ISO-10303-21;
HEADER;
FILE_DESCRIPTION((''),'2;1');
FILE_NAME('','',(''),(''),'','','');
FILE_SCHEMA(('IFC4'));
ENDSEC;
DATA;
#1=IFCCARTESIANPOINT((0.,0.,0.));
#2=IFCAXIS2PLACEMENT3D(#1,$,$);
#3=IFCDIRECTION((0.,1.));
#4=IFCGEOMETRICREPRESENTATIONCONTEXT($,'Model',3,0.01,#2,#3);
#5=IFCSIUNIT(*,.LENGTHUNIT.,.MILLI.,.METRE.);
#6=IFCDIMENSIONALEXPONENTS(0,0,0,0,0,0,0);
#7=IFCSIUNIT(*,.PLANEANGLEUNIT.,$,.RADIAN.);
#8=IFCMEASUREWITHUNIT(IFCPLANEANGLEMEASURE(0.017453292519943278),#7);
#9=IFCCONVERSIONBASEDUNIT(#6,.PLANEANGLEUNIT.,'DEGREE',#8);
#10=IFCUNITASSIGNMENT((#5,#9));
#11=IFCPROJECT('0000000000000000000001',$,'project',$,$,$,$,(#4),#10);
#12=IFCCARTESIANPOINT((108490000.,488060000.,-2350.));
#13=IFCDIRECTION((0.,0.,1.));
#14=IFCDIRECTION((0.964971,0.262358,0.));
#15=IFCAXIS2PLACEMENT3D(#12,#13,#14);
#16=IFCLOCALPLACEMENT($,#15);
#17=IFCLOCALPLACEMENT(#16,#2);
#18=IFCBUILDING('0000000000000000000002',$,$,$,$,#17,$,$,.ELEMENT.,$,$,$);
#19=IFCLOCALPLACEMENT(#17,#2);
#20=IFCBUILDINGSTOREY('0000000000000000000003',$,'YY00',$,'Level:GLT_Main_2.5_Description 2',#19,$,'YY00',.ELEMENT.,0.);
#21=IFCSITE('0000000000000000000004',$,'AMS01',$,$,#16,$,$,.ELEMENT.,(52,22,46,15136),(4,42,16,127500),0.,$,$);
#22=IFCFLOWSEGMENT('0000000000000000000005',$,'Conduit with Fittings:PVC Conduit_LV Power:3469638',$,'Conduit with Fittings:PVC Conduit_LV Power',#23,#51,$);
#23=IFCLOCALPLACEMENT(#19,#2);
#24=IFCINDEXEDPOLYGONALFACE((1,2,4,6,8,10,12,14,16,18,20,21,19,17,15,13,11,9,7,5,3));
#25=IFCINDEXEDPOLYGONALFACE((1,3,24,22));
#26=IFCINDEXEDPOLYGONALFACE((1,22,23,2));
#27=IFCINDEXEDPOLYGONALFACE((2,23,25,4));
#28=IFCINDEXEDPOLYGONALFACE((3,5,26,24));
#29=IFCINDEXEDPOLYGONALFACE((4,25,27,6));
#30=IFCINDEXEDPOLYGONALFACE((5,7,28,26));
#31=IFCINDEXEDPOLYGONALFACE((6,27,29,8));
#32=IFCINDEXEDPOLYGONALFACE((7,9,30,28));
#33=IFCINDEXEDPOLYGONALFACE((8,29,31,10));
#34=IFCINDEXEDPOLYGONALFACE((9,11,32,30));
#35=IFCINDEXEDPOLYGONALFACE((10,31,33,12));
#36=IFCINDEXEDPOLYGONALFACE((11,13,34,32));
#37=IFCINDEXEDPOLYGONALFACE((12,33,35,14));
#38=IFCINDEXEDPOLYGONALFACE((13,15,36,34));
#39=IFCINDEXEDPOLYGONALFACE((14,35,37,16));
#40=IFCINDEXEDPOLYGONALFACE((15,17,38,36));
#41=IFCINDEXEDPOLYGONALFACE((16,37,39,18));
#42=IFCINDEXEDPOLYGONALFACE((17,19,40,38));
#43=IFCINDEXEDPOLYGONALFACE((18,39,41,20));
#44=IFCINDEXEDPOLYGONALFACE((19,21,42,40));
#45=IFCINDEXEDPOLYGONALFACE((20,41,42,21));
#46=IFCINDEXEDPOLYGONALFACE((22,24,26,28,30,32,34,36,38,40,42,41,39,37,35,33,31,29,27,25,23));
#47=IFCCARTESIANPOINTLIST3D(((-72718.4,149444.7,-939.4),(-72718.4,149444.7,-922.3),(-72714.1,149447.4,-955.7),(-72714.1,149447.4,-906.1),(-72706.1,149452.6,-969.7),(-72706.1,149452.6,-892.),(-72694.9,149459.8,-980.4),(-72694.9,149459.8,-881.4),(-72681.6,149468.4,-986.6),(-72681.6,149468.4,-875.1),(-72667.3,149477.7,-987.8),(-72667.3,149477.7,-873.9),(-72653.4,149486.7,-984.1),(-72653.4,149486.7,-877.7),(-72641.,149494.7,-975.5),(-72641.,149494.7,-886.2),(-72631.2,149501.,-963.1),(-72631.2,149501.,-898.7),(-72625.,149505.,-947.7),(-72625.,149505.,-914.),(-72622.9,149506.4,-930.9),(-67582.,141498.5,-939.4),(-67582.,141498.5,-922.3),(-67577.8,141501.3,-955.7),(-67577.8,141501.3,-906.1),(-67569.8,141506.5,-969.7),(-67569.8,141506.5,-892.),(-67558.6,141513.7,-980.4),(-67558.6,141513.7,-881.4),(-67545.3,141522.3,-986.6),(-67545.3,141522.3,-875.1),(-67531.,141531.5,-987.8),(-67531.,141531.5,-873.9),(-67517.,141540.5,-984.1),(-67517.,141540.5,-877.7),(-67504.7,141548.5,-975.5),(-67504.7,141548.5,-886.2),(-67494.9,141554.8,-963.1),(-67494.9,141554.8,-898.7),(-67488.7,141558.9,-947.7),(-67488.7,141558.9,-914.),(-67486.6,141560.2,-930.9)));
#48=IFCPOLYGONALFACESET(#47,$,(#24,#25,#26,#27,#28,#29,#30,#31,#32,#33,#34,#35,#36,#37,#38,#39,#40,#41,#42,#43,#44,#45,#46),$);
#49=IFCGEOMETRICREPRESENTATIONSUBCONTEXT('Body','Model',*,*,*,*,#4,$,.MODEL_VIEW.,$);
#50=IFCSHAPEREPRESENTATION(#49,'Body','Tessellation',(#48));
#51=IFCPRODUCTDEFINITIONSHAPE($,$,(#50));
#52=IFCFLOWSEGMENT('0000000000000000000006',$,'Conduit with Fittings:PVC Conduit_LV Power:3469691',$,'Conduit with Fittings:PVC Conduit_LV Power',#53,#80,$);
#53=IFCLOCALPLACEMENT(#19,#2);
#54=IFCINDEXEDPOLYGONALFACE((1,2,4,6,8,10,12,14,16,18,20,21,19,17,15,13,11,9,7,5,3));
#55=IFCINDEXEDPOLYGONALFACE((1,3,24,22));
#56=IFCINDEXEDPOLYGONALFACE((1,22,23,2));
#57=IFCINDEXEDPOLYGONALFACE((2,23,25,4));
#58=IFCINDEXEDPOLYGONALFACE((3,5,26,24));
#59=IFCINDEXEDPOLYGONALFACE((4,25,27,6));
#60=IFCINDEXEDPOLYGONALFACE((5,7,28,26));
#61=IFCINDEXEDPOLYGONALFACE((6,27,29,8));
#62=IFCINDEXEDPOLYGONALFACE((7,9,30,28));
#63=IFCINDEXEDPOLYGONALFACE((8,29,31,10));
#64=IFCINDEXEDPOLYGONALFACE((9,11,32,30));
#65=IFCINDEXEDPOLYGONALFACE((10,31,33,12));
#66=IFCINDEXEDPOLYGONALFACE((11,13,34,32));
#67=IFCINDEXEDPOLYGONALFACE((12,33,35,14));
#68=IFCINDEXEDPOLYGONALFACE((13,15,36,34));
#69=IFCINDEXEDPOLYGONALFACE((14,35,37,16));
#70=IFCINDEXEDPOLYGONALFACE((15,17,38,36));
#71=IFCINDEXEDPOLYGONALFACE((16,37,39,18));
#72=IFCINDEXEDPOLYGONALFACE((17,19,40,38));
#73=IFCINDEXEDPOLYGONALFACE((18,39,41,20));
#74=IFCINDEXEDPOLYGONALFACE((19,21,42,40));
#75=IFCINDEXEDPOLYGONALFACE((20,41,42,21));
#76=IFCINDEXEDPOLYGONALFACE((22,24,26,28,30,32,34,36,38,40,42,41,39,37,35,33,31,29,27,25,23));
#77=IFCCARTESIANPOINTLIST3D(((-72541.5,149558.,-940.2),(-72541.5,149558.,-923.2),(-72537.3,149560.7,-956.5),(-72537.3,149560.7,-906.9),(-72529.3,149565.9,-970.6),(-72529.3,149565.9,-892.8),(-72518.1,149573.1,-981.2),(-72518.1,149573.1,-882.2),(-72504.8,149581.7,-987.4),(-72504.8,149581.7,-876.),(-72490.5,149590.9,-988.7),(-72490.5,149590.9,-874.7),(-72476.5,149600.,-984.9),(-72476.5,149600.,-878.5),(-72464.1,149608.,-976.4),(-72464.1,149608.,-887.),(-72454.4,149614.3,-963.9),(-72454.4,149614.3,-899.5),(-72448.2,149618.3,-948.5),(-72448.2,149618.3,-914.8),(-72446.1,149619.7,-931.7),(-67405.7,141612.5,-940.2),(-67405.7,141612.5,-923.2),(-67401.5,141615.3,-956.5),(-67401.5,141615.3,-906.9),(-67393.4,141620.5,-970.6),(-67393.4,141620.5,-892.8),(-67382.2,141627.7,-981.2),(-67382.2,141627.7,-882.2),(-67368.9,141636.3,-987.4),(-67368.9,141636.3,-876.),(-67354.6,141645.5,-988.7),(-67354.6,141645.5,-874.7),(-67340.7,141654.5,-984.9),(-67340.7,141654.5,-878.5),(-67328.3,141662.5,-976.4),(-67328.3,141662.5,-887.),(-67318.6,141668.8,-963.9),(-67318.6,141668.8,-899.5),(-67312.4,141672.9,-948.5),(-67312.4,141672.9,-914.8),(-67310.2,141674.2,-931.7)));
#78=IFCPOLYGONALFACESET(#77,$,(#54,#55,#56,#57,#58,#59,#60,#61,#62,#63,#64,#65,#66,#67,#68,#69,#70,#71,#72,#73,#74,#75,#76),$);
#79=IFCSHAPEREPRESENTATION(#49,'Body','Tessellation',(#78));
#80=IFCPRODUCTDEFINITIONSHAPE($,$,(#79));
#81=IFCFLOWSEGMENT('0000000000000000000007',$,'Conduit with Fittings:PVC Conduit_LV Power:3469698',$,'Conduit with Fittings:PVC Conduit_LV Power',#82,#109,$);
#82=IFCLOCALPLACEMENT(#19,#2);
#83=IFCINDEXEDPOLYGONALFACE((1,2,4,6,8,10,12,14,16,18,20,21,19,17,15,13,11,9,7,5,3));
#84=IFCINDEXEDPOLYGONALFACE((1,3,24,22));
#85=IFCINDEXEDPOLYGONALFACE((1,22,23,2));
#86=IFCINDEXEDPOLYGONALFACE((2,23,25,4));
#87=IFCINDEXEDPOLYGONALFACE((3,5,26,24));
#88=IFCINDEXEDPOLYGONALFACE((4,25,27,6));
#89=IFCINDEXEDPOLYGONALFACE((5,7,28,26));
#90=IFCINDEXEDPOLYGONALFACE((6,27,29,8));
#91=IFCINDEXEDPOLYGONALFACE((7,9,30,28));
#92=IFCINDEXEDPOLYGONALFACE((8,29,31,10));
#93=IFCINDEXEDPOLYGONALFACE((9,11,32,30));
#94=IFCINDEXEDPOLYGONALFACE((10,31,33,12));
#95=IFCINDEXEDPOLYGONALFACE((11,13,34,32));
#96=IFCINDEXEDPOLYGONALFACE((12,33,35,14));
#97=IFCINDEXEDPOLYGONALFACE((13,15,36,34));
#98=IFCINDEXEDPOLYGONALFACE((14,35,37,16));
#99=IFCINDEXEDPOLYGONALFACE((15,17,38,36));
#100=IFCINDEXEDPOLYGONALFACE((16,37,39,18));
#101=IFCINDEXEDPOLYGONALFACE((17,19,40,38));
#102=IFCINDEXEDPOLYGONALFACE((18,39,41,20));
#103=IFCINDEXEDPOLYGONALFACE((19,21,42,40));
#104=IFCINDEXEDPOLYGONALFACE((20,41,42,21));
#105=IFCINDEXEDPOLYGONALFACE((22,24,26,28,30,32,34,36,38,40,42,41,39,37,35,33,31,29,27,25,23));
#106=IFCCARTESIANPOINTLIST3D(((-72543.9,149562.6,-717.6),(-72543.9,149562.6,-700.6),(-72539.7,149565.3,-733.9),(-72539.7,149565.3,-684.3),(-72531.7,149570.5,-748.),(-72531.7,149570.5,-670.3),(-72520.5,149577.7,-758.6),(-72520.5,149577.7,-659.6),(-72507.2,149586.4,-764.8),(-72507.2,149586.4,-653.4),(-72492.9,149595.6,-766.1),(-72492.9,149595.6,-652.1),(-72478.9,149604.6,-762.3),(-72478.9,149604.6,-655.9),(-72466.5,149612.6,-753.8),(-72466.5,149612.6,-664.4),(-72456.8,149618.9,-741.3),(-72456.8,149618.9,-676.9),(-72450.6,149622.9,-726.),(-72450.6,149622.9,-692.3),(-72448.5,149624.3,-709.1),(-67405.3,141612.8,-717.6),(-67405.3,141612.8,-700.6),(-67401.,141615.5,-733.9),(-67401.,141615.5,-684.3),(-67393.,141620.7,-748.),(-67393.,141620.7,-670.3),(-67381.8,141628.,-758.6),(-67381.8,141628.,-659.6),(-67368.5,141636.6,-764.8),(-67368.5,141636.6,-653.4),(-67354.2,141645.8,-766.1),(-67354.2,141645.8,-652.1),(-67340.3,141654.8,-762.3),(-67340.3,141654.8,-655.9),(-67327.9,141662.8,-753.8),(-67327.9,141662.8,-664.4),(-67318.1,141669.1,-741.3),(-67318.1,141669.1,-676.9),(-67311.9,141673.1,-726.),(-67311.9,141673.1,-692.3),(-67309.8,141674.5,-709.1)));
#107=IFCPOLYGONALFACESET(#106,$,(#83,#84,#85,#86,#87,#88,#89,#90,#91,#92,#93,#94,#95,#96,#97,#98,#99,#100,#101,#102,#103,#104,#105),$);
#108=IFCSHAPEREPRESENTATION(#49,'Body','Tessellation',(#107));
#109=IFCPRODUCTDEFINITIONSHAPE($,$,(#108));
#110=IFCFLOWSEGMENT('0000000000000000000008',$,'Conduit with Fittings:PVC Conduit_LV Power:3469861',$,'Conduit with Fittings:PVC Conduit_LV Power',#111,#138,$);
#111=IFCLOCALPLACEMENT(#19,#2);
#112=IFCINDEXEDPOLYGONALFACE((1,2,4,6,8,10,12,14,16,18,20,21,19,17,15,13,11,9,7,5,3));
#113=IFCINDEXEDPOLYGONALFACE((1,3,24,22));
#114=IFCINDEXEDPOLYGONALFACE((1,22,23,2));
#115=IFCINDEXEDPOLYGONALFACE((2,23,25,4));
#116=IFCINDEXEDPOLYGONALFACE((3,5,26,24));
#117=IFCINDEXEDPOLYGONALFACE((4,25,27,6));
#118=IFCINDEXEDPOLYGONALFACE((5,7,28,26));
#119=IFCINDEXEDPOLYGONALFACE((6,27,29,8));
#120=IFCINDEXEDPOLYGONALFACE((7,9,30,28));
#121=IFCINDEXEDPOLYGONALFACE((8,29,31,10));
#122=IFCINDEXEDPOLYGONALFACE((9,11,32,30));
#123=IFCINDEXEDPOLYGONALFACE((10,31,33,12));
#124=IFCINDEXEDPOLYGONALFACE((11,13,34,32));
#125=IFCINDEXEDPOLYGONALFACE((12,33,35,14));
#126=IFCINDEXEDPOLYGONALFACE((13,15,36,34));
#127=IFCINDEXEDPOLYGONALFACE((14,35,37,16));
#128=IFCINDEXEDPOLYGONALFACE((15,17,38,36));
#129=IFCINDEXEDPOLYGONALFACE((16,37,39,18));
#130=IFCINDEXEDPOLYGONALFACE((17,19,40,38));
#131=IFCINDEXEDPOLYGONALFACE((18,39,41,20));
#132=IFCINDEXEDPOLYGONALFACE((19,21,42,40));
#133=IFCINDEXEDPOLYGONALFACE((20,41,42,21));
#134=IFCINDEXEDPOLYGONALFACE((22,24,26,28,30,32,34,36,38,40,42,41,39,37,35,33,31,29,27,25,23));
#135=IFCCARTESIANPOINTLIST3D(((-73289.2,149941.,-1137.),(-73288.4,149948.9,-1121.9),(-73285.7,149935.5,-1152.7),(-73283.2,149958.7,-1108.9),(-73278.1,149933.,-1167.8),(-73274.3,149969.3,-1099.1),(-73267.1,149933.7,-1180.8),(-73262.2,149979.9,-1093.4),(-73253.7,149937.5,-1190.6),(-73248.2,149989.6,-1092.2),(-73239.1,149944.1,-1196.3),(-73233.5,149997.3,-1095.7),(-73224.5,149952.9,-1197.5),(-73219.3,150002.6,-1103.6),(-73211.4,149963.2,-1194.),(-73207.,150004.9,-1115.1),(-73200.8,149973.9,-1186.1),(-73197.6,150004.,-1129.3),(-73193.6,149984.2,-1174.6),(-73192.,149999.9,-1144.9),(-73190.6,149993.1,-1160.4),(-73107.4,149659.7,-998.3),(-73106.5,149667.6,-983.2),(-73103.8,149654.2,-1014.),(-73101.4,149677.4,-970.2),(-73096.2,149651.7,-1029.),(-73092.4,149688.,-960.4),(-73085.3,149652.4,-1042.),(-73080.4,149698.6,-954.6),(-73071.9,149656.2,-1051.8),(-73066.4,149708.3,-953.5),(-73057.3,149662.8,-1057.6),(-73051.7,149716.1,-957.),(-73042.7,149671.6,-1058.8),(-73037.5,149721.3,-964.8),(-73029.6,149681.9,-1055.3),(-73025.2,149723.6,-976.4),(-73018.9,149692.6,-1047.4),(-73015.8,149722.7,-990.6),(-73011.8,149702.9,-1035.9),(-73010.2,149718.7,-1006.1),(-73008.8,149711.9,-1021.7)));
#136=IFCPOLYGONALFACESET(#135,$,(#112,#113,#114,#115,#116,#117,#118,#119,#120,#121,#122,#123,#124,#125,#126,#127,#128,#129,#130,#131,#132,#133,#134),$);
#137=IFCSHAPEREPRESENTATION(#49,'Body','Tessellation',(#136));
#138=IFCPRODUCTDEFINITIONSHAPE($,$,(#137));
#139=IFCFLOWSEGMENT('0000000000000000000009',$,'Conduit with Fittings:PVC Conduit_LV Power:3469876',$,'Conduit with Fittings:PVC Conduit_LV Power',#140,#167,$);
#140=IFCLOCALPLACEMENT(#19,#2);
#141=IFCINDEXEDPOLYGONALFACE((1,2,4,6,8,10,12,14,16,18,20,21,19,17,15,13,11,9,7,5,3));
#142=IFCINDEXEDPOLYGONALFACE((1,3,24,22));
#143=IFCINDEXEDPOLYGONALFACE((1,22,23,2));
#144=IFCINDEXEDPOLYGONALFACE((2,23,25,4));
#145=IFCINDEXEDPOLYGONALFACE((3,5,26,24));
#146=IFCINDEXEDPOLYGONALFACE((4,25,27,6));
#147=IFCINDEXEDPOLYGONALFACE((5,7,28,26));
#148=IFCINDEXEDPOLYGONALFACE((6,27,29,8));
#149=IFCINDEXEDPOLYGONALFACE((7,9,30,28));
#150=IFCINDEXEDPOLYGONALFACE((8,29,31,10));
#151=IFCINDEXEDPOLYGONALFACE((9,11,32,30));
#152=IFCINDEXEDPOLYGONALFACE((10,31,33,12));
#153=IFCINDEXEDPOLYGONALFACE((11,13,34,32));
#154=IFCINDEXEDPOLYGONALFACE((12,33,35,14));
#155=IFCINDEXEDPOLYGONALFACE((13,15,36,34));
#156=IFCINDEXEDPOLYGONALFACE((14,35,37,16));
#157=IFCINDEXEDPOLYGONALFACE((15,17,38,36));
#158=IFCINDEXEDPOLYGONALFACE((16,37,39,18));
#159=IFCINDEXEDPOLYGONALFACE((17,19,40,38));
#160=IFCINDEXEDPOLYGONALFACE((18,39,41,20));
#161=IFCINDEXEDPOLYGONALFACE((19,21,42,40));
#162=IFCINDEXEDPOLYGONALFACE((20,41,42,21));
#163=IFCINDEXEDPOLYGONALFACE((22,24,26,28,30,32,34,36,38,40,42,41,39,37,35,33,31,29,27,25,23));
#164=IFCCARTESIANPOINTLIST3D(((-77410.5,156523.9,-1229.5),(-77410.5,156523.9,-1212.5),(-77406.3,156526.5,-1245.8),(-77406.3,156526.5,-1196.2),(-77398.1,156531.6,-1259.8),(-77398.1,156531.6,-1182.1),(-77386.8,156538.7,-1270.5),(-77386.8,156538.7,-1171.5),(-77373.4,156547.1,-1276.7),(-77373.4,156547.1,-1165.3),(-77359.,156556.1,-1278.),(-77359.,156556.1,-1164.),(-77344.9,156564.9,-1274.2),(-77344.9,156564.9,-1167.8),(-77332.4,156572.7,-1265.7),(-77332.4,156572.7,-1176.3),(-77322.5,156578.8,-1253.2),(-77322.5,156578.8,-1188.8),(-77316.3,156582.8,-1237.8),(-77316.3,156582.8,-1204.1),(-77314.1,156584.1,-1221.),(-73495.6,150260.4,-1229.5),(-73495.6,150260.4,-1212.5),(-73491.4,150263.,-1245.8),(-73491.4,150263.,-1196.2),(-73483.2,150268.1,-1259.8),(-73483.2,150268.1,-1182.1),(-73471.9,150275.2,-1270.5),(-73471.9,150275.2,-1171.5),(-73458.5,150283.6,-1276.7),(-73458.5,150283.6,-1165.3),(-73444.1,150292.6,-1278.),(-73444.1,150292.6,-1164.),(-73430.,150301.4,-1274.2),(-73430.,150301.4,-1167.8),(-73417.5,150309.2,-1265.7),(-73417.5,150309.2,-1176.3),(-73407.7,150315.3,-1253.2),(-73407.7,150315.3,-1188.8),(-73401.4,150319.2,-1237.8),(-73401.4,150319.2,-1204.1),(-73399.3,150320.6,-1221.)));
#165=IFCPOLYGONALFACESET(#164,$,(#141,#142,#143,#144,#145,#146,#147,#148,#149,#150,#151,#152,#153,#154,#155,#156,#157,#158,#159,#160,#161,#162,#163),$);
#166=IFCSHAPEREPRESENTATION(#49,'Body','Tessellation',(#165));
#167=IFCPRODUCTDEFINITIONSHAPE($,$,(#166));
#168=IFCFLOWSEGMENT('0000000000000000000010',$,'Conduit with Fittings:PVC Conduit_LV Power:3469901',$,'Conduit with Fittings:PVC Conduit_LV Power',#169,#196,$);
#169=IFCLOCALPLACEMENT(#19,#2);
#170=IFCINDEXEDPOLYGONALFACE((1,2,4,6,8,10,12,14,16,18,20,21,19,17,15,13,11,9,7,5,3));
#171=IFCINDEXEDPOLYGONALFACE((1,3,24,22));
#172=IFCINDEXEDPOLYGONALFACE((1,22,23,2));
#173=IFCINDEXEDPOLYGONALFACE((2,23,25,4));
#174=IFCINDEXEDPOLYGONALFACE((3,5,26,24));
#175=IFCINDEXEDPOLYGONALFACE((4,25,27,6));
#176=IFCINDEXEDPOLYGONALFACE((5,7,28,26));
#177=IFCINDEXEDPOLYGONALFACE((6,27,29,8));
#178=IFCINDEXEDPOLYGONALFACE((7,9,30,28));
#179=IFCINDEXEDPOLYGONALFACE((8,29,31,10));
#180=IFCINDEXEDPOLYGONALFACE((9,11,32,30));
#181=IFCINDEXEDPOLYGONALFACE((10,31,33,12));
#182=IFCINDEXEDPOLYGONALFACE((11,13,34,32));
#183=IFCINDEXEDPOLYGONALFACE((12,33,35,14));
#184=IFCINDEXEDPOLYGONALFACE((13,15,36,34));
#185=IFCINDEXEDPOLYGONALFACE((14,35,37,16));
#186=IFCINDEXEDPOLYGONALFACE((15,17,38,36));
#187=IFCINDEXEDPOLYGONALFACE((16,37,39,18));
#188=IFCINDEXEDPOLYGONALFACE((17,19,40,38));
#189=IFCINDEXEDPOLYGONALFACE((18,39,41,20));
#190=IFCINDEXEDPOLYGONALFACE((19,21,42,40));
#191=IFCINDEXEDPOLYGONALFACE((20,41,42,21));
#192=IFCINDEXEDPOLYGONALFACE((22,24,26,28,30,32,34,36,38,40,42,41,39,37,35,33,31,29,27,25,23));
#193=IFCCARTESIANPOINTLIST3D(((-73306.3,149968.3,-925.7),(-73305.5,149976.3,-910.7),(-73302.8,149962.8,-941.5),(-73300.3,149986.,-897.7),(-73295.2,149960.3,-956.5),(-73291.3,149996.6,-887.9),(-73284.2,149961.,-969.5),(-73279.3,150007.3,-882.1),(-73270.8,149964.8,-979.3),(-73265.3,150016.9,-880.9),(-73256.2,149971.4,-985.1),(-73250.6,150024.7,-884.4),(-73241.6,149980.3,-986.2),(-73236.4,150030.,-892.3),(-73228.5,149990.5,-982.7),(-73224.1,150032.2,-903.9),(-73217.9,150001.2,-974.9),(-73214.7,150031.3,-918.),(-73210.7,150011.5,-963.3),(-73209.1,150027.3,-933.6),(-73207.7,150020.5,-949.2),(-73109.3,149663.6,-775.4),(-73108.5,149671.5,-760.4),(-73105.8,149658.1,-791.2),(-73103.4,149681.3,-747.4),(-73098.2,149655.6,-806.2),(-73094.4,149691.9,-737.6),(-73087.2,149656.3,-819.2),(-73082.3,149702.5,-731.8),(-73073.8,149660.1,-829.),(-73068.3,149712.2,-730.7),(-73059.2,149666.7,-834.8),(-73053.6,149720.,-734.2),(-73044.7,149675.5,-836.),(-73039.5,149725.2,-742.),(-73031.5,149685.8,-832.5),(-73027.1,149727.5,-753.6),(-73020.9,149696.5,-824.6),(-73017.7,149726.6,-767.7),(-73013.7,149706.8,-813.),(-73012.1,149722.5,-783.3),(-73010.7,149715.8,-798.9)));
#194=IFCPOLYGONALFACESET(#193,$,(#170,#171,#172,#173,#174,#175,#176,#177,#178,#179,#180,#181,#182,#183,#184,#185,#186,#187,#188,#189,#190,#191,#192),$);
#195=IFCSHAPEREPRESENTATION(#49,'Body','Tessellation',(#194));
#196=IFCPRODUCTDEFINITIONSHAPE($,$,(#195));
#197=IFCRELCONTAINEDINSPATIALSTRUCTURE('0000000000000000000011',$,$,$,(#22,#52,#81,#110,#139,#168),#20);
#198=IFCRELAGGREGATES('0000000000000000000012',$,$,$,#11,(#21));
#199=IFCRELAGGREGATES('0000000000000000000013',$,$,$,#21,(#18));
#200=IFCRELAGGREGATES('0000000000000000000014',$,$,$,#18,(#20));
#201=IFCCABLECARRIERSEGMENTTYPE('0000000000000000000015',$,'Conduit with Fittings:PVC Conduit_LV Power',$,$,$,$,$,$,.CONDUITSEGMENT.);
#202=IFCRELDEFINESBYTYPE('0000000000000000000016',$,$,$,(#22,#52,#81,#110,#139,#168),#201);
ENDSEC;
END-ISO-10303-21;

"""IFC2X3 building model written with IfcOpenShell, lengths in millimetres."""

from ifc_helpers import new_model, entity, si_unit, converted_unit, direction, frame, frame_2d, origin, origin_2d_with_axis, place, context, subcontext, project, spatial, circle, extrude, type_object, element, save


model = new_model("IFC2X3")

# Units and contexts
model_context = context("Model", 3, precision=0.01, world=origin(), true_north=direction((0.0, 1.0)))
body_context = subcontext(model_context, "Body", "Model", "MODEL_VIEW")
ifc_project = project(units=[si_unit("LENGTHUNIT", "METRE", prefix="MILLI"), converted_unit("PLANEANGLEUNIT", "DEGREE", entity("IfcPlaneAngleMeasure", 0.017453292519943278), si_unit("PLANEANGLEUNIT", "RADIAN"), dimensions=[0, 0, 0, 0, 0, 0, 0])], contexts=[model_context])

# Site, building, storey
site_placement = place(None, frame((108490000.0, 488060000.0, -2350.0), z_axis=(0.0, 0.0, 1.0), x_axis=(0.964971, 0.262358, 0.0)))
site = spatial("IfcSite", under=ifc_project, at=site_placement, Name="AMS01", CompositionType="ELEMENT", RefLatitude=(52, 22, 46, 15136), RefLongitude=(4, 42, 16, 127500), RefElevation=0.0)
building_placement = place(site_placement, origin())
building = spatial("IfcBuilding", under=site, at=building_placement, CompositionType="ELEMENT")
storey_placement = place(building_placement, origin())
storey = spatial("IfcBuildingStorey", under=building, at=storey_placement, Name="YY00", ObjectType="Level:GLT_Main_2.5_Description 2", LongName="YY00", CompositionType="ELEMENT", Elevation=0.0)

# Flow segments
cable_carrier_segment_type = type_object("IfcCableCarrierSegmentType", Name="Conduit with Fittings:PVC Conduit_LV Power", PredefinedType="CONDUITSEGMENT")
flow_segment_1_placement = place(storey_placement, origin())
element("IfcFlowSegment", 1, at=flow_segment_1_placement, inside=storey, type_object=cable_carrier_segment_type, Name="Conduit with Fittings:PVC Conduit_LV Power:3469638", ObjectType="Conduit with Fittings:PVC Conduit_LV Power", context=body_context, shape_type="SweptSolid", body=[
    extrude(circle(Radius=57.2, at=origin_2d_with_axis()), frame((-67534.6, 141529.2, -930.9), z_axis=(-0.542856, 0.839826, 0.0), x_axis=(0.839826, 0.542856, 0.0)), (0.0, 0.0, 1.0), 9461.6),
])
flow_segment_2_placement = place(storey_placement, origin())
element("IfcFlowSegment", 2, at=flow_segment_2_placement, inside=storey, type_object=cable_carrier_segment_type, Name="Conduit with Fittings:PVC Conduit_LV Power:3469691", ObjectType="Conduit with Fittings:PVC Conduit_LV Power", context=body_context, shape_type="SweptSolid", body=[
    extrude(circle(Radius=57.2, at=frame_2d((0.0, 0.0), x_axis=(1.0, 0.0))), frame((-67358.2, 141643.2, -931.7), z_axis=(-0.542856, 0.839826, 0.0), x_axis=(0.839826, 0.542856, 0.0)), (0.0, 0.0, 1.0), 9460.8),
])
flow_segment_3_placement = place(storey_placement, origin())
element("IfcFlowSegment", 3, at=flow_segment_3_placement, inside=storey, type_object=cable_carrier_segment_type, Name="Conduit with Fittings:PVC Conduit_LV Power:3469698", ObjectType="Conduit with Fittings:PVC Conduit_LV Power", context=body_context, shape_type="SweptSolid", body=[
    extrude(circle(Radius=57.2, at=frame_2d((0.0, 0.0), x_axis=(1.0, 0.0))), frame((-67357.8, 141643.5, -709.1), z_axis=(-0.542856, 0.839826, 0.0), x_axis=(0.839826, 0.542856, 0.0)), (0.0, 0.0, 1.0), 9466.0),
])
flow_segment_4_placement = place(storey_placement, origin())
element("IfcFlowSegment", 4, at=flow_segment_4_placement, inside=storey, type_object=cable_carrier_segment_type, Name="Conduit with Fittings:PVC Conduit_LV Power:3469861", ObjectType="Conduit with Fittings:PVC Conduit_LV Power", context=body_context, shape_type="SweptSolid", body=[
    extrude(circle(Radius=57.2, at=frame_2d((0.0, 0.0), x_axis=(1.0, 0.0))), frame((-73240.0, 149968.9, -1144.9), z_axis=(0.501534, -0.775898, 0.382683), x_axis=(0.839826, 0.542856, 0.0)), (0.0, 0.0, 1.0), 362.5),
])
flow_segment_5_placement = place(storey_placement, origin())
element("IfcFlowSegment", 5, at=flow_segment_5_placement, inside=storey, type_object=cable_carrier_segment_type, Name="Conduit with Fittings:PVC Conduit_LV Power:3469876", ObjectType="Conduit with Fittings:PVC Conduit_LV Power", context=body_context, shape_type="SweptSolid", body=[
    extrude(circle(Radius=57.2, at=frame_2d((0.0, 0.0), x_axis=(1.0, 0.0))), frame((-77362.6, 156553.8, -1221.0), z_axis=(0.530017, -0.847987, 0.0), x_axis=(0.847987, 0.530017, 0.0)), (0.0, 0.0, 1.0), 7386.3),
])
flow_segment_6_placement = place(storey_placement, origin())
element("IfcFlowSegment", 6, at=flow_segment_6_placement, inside=storey, type_object=cable_carrier_segment_type, Name="Conduit with Fittings:PVC Conduit_LV Power:3469901", ObjectType="Conduit with Fittings:PVC Conduit_LV Power", context=body_context, shape_type="SweptSolid", body=[
    extrude(circle(Radius=57.2, at=frame_2d((0.0, 0.0), x_axis=(1.0, 0.0))), frame((-73257.1, 149996.2, -933.6), z_axis=(0.501534, -0.775898, 0.382683), x_axis=(0.839826, 0.542856, 0.0)), (0.0, 0.0, 1.0), 392.7),
])

save(model, "model.ifc")
